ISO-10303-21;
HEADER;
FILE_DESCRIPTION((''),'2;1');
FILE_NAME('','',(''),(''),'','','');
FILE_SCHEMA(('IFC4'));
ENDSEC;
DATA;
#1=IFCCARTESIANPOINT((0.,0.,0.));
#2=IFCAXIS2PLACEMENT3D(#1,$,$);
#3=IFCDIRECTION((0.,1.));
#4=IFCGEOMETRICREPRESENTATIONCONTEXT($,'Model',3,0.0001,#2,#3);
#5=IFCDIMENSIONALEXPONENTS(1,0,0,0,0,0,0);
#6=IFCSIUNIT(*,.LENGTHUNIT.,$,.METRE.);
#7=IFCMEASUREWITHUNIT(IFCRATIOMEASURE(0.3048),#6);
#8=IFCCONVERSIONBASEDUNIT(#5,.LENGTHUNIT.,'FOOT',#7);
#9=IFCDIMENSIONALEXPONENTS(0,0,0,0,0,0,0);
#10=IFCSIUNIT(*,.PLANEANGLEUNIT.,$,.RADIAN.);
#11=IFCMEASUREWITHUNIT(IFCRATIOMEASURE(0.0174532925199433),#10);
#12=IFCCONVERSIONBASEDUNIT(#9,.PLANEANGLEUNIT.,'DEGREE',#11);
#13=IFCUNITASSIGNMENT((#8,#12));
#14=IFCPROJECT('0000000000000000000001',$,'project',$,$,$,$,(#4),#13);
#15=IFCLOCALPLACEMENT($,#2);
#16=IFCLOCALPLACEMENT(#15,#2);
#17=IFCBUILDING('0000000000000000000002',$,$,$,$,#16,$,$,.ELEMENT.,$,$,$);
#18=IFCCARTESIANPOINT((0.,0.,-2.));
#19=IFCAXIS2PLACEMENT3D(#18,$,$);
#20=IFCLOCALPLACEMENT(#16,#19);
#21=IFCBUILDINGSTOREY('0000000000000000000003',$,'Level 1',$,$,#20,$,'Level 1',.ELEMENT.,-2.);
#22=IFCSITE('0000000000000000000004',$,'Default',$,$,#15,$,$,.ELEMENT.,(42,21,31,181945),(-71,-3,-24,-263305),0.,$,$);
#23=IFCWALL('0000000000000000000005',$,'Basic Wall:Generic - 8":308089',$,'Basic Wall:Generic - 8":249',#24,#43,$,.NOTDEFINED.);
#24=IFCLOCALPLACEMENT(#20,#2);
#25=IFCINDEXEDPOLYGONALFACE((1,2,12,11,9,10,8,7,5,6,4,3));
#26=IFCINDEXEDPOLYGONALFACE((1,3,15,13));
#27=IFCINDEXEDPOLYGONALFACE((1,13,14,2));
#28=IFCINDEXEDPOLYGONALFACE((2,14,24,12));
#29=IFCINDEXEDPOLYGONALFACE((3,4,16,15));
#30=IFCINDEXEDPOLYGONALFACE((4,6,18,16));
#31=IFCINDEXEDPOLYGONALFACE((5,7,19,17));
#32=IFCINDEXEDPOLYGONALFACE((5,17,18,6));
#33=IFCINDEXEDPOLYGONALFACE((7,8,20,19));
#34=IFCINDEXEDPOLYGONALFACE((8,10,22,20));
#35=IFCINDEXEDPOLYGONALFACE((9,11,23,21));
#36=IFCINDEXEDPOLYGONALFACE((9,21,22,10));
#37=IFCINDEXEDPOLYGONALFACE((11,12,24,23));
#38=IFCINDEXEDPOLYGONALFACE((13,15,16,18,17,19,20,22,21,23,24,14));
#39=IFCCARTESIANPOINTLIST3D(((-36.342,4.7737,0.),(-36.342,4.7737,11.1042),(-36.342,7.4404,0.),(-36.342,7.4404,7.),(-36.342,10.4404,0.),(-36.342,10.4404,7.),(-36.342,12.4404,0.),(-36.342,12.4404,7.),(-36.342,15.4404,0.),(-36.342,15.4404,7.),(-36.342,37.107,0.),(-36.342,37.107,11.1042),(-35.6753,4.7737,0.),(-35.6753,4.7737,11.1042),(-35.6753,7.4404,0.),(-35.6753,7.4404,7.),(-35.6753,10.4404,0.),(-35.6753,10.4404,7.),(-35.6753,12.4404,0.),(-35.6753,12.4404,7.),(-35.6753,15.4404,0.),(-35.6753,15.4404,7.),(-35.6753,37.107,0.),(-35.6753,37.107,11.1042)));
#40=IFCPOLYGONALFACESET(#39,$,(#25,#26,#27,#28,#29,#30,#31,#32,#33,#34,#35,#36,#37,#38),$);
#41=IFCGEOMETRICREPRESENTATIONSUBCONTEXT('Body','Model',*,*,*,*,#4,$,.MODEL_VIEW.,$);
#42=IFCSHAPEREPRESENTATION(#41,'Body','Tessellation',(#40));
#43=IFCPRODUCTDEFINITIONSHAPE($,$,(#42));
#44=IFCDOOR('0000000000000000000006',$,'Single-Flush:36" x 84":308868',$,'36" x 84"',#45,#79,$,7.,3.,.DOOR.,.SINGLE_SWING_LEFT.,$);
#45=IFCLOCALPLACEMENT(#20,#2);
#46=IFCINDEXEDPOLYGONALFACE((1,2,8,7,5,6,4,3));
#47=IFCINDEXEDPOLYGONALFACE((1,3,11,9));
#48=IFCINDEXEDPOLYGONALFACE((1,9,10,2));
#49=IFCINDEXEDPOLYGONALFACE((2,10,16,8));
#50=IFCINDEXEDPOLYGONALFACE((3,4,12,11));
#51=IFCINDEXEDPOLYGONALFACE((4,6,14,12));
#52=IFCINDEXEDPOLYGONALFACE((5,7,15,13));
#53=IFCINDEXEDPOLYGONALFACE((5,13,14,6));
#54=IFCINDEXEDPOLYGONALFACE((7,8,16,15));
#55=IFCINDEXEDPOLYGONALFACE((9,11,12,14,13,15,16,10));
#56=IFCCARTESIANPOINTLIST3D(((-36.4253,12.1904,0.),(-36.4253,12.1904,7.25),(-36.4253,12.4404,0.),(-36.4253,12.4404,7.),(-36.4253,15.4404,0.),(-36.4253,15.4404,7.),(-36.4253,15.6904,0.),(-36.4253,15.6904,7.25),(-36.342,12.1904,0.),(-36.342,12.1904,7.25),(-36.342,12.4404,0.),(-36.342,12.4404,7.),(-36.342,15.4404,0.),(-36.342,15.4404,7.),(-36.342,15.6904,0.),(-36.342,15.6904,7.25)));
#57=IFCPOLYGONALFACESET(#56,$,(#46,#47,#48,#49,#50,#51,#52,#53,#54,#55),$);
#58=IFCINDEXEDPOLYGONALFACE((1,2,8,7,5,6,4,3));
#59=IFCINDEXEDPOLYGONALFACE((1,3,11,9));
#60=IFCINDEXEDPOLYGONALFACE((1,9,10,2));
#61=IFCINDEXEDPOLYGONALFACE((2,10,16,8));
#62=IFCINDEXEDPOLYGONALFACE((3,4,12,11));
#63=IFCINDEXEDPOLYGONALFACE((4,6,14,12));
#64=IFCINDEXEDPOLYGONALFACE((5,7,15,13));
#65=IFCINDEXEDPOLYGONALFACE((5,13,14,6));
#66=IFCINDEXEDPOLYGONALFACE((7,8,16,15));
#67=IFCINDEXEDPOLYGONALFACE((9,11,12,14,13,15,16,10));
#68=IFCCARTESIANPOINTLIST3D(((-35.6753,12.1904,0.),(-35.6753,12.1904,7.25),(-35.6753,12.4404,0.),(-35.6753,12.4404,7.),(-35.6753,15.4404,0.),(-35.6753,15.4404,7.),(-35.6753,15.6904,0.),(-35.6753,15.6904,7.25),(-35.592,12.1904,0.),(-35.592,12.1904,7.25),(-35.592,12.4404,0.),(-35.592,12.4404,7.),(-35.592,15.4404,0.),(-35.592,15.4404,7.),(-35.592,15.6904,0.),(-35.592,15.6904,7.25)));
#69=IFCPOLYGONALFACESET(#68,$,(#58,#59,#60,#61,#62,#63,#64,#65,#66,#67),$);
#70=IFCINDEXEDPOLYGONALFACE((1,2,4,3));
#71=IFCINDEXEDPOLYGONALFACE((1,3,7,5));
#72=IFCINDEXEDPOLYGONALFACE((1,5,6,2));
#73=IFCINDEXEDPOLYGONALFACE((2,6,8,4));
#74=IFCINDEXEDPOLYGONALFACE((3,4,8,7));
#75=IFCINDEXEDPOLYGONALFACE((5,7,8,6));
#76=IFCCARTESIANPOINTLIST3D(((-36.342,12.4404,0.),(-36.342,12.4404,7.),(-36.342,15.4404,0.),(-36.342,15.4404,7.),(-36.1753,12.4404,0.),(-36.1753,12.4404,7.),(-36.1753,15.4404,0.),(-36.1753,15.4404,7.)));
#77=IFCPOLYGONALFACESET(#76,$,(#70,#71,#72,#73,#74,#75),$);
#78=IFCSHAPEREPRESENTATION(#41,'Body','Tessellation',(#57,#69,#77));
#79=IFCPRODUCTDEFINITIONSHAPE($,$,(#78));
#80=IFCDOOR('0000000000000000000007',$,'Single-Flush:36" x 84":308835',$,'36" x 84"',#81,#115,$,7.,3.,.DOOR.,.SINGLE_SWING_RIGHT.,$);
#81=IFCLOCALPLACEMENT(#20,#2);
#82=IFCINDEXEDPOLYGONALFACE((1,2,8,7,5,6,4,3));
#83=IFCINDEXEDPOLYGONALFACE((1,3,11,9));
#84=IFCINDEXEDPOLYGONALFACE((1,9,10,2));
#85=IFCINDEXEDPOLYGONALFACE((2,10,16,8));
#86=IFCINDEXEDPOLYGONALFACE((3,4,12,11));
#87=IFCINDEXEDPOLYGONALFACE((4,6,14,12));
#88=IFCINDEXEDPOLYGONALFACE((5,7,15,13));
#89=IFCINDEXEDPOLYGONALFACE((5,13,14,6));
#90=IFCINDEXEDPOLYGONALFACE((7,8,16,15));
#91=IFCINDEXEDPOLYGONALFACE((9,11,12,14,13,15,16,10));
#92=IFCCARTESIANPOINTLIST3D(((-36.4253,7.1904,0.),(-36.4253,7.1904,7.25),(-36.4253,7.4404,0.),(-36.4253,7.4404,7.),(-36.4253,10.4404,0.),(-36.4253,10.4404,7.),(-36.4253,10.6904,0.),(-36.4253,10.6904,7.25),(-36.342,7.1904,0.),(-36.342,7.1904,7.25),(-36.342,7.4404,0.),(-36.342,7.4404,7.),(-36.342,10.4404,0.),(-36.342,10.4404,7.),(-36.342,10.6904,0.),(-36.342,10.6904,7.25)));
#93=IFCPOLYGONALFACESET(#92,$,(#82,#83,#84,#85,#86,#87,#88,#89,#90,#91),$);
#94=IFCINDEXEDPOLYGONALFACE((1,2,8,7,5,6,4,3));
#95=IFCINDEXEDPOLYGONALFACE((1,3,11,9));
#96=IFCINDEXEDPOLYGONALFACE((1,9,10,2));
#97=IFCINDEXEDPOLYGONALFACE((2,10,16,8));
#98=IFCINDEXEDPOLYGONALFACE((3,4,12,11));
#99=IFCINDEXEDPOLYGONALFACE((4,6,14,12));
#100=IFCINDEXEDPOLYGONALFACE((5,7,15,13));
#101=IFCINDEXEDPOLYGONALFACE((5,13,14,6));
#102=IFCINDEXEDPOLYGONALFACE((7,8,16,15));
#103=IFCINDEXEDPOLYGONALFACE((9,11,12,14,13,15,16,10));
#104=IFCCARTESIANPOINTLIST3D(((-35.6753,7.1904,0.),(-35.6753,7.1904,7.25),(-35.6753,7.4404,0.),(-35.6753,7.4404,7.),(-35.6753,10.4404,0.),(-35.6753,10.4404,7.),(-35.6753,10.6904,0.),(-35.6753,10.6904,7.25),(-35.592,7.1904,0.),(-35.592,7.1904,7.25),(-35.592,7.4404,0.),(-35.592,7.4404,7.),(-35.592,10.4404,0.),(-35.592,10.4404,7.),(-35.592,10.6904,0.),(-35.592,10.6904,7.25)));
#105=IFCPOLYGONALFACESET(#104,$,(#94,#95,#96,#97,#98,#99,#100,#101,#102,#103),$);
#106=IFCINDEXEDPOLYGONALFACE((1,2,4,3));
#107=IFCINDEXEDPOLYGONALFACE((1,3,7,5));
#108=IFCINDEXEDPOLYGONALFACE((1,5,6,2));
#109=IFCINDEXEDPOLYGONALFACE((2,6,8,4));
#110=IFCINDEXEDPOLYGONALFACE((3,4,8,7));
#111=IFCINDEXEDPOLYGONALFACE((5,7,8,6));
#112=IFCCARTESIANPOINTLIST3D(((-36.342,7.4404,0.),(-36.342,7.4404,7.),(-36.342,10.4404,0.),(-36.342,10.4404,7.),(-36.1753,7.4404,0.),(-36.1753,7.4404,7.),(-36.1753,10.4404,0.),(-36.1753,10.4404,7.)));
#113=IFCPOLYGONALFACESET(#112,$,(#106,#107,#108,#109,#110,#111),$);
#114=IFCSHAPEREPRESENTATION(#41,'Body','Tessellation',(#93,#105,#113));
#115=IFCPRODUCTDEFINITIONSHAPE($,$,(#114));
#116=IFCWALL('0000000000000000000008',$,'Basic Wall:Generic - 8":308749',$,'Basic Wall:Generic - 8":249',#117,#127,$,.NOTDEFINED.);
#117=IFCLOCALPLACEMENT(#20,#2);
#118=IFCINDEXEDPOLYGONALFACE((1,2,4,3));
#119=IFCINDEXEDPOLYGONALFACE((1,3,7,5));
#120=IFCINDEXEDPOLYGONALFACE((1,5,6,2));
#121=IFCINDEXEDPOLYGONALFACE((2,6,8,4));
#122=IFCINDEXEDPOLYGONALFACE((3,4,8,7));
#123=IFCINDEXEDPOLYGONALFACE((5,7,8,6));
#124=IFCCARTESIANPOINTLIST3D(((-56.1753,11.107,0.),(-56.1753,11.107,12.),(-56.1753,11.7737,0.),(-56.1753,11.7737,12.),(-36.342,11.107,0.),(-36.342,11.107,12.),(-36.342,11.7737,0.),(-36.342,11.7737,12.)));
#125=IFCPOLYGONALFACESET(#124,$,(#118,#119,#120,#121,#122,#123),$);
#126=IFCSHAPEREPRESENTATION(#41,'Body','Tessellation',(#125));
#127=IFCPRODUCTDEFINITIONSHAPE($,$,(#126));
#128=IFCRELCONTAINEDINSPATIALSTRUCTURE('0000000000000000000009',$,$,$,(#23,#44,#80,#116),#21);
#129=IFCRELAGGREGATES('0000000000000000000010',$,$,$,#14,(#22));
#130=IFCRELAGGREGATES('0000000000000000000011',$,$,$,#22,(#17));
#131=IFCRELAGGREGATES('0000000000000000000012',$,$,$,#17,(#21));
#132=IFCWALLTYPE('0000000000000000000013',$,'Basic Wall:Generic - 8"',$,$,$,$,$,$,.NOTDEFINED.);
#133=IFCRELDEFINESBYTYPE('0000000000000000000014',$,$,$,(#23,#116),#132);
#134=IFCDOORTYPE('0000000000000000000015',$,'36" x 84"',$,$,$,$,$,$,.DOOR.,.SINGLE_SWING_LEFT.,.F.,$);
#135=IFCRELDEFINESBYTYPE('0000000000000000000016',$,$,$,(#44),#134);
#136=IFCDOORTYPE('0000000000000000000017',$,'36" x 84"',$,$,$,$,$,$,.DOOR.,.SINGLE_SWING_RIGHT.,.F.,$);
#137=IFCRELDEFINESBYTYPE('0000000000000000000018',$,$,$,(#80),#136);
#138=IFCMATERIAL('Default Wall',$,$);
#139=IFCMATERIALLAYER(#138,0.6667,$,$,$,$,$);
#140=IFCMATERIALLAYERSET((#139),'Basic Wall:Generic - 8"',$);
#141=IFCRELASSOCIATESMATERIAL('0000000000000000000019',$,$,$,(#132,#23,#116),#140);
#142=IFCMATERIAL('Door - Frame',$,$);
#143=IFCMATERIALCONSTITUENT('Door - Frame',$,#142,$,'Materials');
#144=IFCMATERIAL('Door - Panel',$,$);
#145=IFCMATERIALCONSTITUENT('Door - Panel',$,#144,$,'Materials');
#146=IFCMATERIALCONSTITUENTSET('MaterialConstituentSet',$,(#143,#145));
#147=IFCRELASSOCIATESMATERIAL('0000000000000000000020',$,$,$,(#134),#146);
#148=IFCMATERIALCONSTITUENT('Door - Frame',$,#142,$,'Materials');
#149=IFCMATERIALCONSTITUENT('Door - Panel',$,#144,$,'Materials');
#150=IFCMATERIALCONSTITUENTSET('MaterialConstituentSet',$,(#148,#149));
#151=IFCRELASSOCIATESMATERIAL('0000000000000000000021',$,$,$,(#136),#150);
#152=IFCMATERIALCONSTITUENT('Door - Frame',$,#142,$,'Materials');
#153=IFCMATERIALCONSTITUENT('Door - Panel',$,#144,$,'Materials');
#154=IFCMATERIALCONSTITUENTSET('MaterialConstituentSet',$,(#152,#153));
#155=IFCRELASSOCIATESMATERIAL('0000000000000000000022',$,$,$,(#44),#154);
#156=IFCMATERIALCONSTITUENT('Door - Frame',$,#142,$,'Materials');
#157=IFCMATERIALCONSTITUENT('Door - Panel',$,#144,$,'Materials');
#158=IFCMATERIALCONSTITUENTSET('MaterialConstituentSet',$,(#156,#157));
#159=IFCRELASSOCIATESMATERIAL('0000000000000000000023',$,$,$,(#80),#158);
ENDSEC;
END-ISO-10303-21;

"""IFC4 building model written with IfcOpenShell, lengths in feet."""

from ifc_helpers import new_model, entity, si_unit, converted_unit, direction, frame, frame_2d, origin, place, context, subcontext, project, spatial, polyline, rectangle, outline, extrude, clip, bounded_halfspace, source, transform, mapped, material, layer, layer_set, layer_usage, constituent, constituent_set, type_object, type_shapes, element, fill, save


model = new_model("IFC4")

# Units and contexts
model_context = context("Model", 3, precision=0.0001, world=origin(), true_north=direction((0.0, 1.0)))
body_context = subcontext(model_context, "Body", "Model", "MODEL_VIEW")
ifc_project = project(units=[converted_unit("LENGTHUNIT", "FOOT", entity("IfcRatioMeasure", 0.3048), si_unit("LENGTHUNIT", "METRE"), dimensions=[1, 0, 0, 0, 0, 0, 0]), converted_unit("PLANEANGLEUNIT", "DEGREE", entity("IfcRatioMeasure", 0.0174532925199433), si_unit("PLANEANGLEUNIT", "RADIAN"), dimensions=[0, 0, 0, 0, 0, 0, 0])], contexts=[model_context])

# Site, building, storey
site_placement = place(None, origin())
site = spatial("IfcSite", under=ifc_project, at=site_placement, Name="Default", CompositionType="ELEMENT", RefLatitude=(42, 21, 31, 181945), RefLongitude=(-71, -3, -24, -263305), RefElevation=0.0)
building_placement = place(site_placement, origin())
building = spatial("IfcBuilding", under=site, at=building_placement, CompositionType="ELEMENT")
storey_placement = place(building_placement, frame((0.0, 0.0, -2.0)))
storey = spatial("IfcBuildingStorey", under=building, at=storey_placement, Name="Level 1", LongName="Level 1", CompositionType="ELEMENT", Elevation=-2.0)

# Shared definitions
ifc_material_1 = material(Name="Default Wall")
ifc_layer = layer(ifc_material_1, 0.6667)
ifc_layer_set = layer_set([ifc_layer], Name="Basic Wall:Generic - 8\"")
wall_type = type_object("IfcWallType", Name="Basic Wall:Generic - 8\"", PredefinedType="NOTDEFINED", material=ifc_layer_set)

# Wall, openings, doors
ifc_material_2 = material(Name="Door - Frame")
ifc_material_3 = material(Name="Door - Panel")
ifc_constituent_1 = constituent(ifc_material_2, Name="Door - Frame", Category="Materials")
ifc_constituent_2 = constituent(ifc_material_3, Name="Door - Panel", Category="Materials")
ifc_constituent_set_1 = constituent_set(constituents=[ifc_constituent_1, ifc_constituent_2], Name="MaterialConstituentSet")
door_type_1 = type_object("IfcDoorType", Name="36\" x 84\"", OperationType="SINGLE_SWING_LEFT", ParameterTakesPrecedence=False, PredefinedType="DOOR", material=ifc_constituent_set_1)
shared_shape_1 = source(origin(), body_context, "Body", "SweptSolid", [
    extrude(outline(polyline([(-1.75, -3.6875), (1.75, -3.6875), (1.75, 3.5625), (1.5, 3.5625), (1.5, -3.4375), (-1.5, -3.4375), (-1.5, 3.5625), (-1.75, 3.5625), (-1.75, -3.6875)])), frame((1.5, 0.75, 3.5625), z_axis=(0.0, -1.0, 0.0), x_axis=(-1.0, 0.0, 0.0)), (0.0, 0.0, 1.0), 0.0833),
    extrude(outline(polyline([(-3.6875, -1.75), (3.5625, -1.75), (3.5625, -1.5), (-3.4375, -1.5), (-3.4375, 1.5), (3.5625, 1.5), (3.5625, 1.75), (-3.6875, 1.75), (-3.6875, -1.75)])), frame((1.5, 0.0, 3.5625), z_axis=(0.0, -1.0, 0.0), x_axis=(0.0, 0.0, -1.0)), (0.0, 0.0, 1.0), 0.0833),
    extrude(rectangle(XDim=3.0, YDim=0.1667, at=frame_2d((0.0, 0.0), x_axis=(1.0, 0.0))), frame((1.5, 0.5833, 0.0)), (0.0, 0.0, 1.0), 7.0),
])
type_shapes(door_type_1, [shared_shape_1])
ifc_constituent_3 = constituent(ifc_material_2, Name="Door - Frame", Category="Materials")
ifc_constituent_4 = constituent(ifc_material_3, Name="Door - Panel", Category="Materials")
ifc_constituent_set_2 = constituent_set(constituents=[ifc_constituent_3, ifc_constituent_4], Name="MaterialConstituentSet")
door_type_2 = type_object("IfcDoorType", Name="36\" x 84\"", OperationType="SINGLE_SWING_RIGHT", ParameterTakesPrecedence=False, PredefinedType="DOOR", material=ifc_constituent_set_2)
shared_shape_2 = source(origin(), body_context, "Body", "SweptSolid", [
    extrude(outline(polyline([(-1.75, -3.6875), (1.75, -3.6875), (1.75, 3.5625), (1.5, 3.5625), (1.5, -3.4375), (-1.5, -3.4375), (-1.5, 3.5625), (-1.75, 3.5625), (-1.75, -3.6875)])), frame((1.5, 0.6667, 3.5625), z_axis=(0.0, 1.0, 0.0), x_axis=(1.0, 0.0, 0.0)), (0.0, 0.0, 1.0), 0.0833),
    extrude(outline(polyline([(-3.6875, -1.75), (3.5625, -1.75), (3.5625, -1.5), (-3.4375, -1.5), (-3.4375, 1.5), (3.5625, 1.5), (3.5625, 1.75), (-3.6875, 1.75), (-3.6875, -1.75)])), frame((1.5, -0.0833, 3.5625), z_axis=(0.0, 1.0, 0.0), x_axis=(0.0, 0.0, -1.0)), (0.0, 0.0, 1.0), 0.0833),
    extrude(rectangle(XDim=0.1667, YDim=3.0, at=frame_2d((0.0, 0.0), x_axis=(1.0, 0.0))), frame((1.5, 0.5833, 0.0), z_axis=(0.0, 0.0, 1.0), x_axis=(0.0, 1.0, 0.0)), (0.0, 0.0, 1.0), 7.0),
])
type_shapes(door_type_2, [shared_shape_2])
ifc_layer_usage_1 = layer_usage(ifc_layer_set, "AXIS2", "NEGATIVE", 0.3333)
wall_1_placement = place(storey_placement, frame((-36.0087, 37.107, 0.0), z_axis=(0.0, 0.0, 1.0), x_axis=(0.0, -1.0, 0.0)))
wall_1 = element("IfcWall", 1, at=wall_1_placement, inside=storey, type_object=wall_type, material=ifc_layer_usage_1, Name="Basic Wall:Generic - 8\":308089", ObjectType="Basic Wall:Generic - 8\":249", PredefinedType="NOTDEFINED", context=body_context, shape_type="Clipping", body=[
    clip(extrude(rectangle(XDim=32.3333, YDim=0.6667, at=frame_2d((16.1667, 0.0), x_axis=(-1.0, 0.0))), origin(), (0.0, 0.0, 1.0), 11.1042), bounded_halfspace(frame((0.0, -0.3333, 11.1042), z_axis=(0.0, 0.0, -1.0), x_axis=(1.0, 0.0, 0.0)), True, frame((0.0, -0.3333, 11.1042), z_axis=(0.0, 0.0, -1.0), x_axis=(1.0, 0.0, 0.0)), polyline([(0.0, 0.0), (0.0, -0.6667), (32.3333, -0.6667), (32.3333, 0.0), (0.0, 0.0)]))),
])
opening_1_placement = place(wall_1_placement, frame((29.6667, 0.3333, 0.0)))
opening_1 = element("IfcOpeningElement", 2, at=opening_1_placement, cuts=wall_1, ObjectType="Opening", PredefinedType="OPENING", context=body_context, shape_type="SweptSolid", body=[
    extrude(rectangle(XDim=3.0, YDim=7.0, at=frame_2d((3.5, 1.5), x_axis=(0.0, 1.0))), frame((0.0, 0.0, 0.0), z_axis=(0.0, -1.0, 0.0), x_axis=(0.0, 0.0, 1.0)), (0.0, 0.0, 1.0), 0.6667),
])
opening_2_placement = place(wall_1_placement, frame((24.6667, 0.3333, 0.0)))
opening_2 = element("IfcOpeningElement", 3, at=opening_2_placement, cuts=wall_1, ObjectType="Opening", PredefinedType="OPENING", context=body_context, shape_type="SweptSolid", body=[
    extrude(rectangle(XDim=3.0, YDim=7.0, at=frame_2d((3.5, 1.5), x_axis=(0.0, -1.0))), frame((0.0, 0.0, 0.0), z_axis=(0.0, -1.0, 0.0), x_axis=(0.0, 0.0, 1.0)), (0.0, 0.0, 1.0), 0.6667),
])
ifc_constituent_5 = constituent(ifc_material_2, Name="Door - Frame", Category="Materials")
ifc_constituent_6 = constituent(ifc_material_3, Name="Door - Panel", Category="Materials")
ifc_constituent_set_3 = constituent_set(constituents=[ifc_constituent_5, ifc_constituent_6], Name="MaterialConstituentSet")
door_1_placement = place(opening_2_placement, frame((0.0, 0.0, 0.0), z_axis=(0.0, 0.0, 1.0), x_axis=(-1.0, 0.0, 0.0)))
door_1 = element("IfcDoor", 4, at=door_1_placement, inside=storey, type_object=door_type_1, material=ifc_constituent_set_3, Name="Single-Flush:36\" x 84\":308868", ObjectType="36\" x 84\"", OperationType="SINGLE_SWING_LEFT", OverallHeight=7.0, OverallWidth=3.0, PredefinedType="DOOR", context=body_context, shape_type="MappedRepresentation", body=[
    mapped(shared_shape_1, transform((0.0, 0.0, 0.0), scale=1.0)),
])
fill(opening_2, door_1)
ifc_constituent_7 = constituent(ifc_material_2, Name="Door - Frame", Category="Materials")
ifc_constituent_8 = constituent(ifc_material_3, Name="Door - Panel", Category="Materials")
ifc_constituent_set_4 = constituent_set(constituents=[ifc_constituent_7, ifc_constituent_8], Name="MaterialConstituentSet")
door_2_placement = place(opening_1_placement, frame((0.0, 0.0, 0.0), z_axis=(0.0, 0.0, 1.0), x_axis=(-1.0, 0.0, 0.0)))
door_2 = element("IfcDoor", 5, at=door_2_placement, inside=storey, type_object=door_type_2, material=ifc_constituent_set_4, Name="Single-Flush:36\" x 84\":308835", ObjectType="36\" x 84\"", OperationType="SINGLE_SWING_RIGHT", OverallHeight=7.0, OverallWidth=3.0, PredefinedType="DOOR", context=body_context, shape_type="MappedRepresentation", body=[
    mapped(shared_shape_2, transform((0.0, 0.0, 0.0), scale=1.0)),
])
fill(opening_1, door_2)

# Wall
ifc_layer_usage_2 = layer_usage(ifc_layer_set, "AXIS2", "NEGATIVE", 0.3333)
wall_2_placement = place(storey_placement, frame((-36.342, 11.4404, 0.0), z_axis=(0.0, 0.0, 1.0), x_axis=(-1.0, 0.0, 0.0)))
element("IfcWall", 6, at=wall_2_placement, inside=storey, type_object=wall_type, material=ifc_layer_usage_2, Name="Basic Wall:Generic - 8\":308749", ObjectType="Basic Wall:Generic - 8\":249", PredefinedType="NOTDEFINED", context=body_context, shape_type="SweptSolid", body=[
    extrude(rectangle(XDim=19.8333, YDim=0.6667, at=frame_2d((9.9167, 0.0), x_axis=(-1.0, 0.0))), origin(), (0.0, 0.0, 1.0), 12.0),
])

save(model, "model.ifc")
